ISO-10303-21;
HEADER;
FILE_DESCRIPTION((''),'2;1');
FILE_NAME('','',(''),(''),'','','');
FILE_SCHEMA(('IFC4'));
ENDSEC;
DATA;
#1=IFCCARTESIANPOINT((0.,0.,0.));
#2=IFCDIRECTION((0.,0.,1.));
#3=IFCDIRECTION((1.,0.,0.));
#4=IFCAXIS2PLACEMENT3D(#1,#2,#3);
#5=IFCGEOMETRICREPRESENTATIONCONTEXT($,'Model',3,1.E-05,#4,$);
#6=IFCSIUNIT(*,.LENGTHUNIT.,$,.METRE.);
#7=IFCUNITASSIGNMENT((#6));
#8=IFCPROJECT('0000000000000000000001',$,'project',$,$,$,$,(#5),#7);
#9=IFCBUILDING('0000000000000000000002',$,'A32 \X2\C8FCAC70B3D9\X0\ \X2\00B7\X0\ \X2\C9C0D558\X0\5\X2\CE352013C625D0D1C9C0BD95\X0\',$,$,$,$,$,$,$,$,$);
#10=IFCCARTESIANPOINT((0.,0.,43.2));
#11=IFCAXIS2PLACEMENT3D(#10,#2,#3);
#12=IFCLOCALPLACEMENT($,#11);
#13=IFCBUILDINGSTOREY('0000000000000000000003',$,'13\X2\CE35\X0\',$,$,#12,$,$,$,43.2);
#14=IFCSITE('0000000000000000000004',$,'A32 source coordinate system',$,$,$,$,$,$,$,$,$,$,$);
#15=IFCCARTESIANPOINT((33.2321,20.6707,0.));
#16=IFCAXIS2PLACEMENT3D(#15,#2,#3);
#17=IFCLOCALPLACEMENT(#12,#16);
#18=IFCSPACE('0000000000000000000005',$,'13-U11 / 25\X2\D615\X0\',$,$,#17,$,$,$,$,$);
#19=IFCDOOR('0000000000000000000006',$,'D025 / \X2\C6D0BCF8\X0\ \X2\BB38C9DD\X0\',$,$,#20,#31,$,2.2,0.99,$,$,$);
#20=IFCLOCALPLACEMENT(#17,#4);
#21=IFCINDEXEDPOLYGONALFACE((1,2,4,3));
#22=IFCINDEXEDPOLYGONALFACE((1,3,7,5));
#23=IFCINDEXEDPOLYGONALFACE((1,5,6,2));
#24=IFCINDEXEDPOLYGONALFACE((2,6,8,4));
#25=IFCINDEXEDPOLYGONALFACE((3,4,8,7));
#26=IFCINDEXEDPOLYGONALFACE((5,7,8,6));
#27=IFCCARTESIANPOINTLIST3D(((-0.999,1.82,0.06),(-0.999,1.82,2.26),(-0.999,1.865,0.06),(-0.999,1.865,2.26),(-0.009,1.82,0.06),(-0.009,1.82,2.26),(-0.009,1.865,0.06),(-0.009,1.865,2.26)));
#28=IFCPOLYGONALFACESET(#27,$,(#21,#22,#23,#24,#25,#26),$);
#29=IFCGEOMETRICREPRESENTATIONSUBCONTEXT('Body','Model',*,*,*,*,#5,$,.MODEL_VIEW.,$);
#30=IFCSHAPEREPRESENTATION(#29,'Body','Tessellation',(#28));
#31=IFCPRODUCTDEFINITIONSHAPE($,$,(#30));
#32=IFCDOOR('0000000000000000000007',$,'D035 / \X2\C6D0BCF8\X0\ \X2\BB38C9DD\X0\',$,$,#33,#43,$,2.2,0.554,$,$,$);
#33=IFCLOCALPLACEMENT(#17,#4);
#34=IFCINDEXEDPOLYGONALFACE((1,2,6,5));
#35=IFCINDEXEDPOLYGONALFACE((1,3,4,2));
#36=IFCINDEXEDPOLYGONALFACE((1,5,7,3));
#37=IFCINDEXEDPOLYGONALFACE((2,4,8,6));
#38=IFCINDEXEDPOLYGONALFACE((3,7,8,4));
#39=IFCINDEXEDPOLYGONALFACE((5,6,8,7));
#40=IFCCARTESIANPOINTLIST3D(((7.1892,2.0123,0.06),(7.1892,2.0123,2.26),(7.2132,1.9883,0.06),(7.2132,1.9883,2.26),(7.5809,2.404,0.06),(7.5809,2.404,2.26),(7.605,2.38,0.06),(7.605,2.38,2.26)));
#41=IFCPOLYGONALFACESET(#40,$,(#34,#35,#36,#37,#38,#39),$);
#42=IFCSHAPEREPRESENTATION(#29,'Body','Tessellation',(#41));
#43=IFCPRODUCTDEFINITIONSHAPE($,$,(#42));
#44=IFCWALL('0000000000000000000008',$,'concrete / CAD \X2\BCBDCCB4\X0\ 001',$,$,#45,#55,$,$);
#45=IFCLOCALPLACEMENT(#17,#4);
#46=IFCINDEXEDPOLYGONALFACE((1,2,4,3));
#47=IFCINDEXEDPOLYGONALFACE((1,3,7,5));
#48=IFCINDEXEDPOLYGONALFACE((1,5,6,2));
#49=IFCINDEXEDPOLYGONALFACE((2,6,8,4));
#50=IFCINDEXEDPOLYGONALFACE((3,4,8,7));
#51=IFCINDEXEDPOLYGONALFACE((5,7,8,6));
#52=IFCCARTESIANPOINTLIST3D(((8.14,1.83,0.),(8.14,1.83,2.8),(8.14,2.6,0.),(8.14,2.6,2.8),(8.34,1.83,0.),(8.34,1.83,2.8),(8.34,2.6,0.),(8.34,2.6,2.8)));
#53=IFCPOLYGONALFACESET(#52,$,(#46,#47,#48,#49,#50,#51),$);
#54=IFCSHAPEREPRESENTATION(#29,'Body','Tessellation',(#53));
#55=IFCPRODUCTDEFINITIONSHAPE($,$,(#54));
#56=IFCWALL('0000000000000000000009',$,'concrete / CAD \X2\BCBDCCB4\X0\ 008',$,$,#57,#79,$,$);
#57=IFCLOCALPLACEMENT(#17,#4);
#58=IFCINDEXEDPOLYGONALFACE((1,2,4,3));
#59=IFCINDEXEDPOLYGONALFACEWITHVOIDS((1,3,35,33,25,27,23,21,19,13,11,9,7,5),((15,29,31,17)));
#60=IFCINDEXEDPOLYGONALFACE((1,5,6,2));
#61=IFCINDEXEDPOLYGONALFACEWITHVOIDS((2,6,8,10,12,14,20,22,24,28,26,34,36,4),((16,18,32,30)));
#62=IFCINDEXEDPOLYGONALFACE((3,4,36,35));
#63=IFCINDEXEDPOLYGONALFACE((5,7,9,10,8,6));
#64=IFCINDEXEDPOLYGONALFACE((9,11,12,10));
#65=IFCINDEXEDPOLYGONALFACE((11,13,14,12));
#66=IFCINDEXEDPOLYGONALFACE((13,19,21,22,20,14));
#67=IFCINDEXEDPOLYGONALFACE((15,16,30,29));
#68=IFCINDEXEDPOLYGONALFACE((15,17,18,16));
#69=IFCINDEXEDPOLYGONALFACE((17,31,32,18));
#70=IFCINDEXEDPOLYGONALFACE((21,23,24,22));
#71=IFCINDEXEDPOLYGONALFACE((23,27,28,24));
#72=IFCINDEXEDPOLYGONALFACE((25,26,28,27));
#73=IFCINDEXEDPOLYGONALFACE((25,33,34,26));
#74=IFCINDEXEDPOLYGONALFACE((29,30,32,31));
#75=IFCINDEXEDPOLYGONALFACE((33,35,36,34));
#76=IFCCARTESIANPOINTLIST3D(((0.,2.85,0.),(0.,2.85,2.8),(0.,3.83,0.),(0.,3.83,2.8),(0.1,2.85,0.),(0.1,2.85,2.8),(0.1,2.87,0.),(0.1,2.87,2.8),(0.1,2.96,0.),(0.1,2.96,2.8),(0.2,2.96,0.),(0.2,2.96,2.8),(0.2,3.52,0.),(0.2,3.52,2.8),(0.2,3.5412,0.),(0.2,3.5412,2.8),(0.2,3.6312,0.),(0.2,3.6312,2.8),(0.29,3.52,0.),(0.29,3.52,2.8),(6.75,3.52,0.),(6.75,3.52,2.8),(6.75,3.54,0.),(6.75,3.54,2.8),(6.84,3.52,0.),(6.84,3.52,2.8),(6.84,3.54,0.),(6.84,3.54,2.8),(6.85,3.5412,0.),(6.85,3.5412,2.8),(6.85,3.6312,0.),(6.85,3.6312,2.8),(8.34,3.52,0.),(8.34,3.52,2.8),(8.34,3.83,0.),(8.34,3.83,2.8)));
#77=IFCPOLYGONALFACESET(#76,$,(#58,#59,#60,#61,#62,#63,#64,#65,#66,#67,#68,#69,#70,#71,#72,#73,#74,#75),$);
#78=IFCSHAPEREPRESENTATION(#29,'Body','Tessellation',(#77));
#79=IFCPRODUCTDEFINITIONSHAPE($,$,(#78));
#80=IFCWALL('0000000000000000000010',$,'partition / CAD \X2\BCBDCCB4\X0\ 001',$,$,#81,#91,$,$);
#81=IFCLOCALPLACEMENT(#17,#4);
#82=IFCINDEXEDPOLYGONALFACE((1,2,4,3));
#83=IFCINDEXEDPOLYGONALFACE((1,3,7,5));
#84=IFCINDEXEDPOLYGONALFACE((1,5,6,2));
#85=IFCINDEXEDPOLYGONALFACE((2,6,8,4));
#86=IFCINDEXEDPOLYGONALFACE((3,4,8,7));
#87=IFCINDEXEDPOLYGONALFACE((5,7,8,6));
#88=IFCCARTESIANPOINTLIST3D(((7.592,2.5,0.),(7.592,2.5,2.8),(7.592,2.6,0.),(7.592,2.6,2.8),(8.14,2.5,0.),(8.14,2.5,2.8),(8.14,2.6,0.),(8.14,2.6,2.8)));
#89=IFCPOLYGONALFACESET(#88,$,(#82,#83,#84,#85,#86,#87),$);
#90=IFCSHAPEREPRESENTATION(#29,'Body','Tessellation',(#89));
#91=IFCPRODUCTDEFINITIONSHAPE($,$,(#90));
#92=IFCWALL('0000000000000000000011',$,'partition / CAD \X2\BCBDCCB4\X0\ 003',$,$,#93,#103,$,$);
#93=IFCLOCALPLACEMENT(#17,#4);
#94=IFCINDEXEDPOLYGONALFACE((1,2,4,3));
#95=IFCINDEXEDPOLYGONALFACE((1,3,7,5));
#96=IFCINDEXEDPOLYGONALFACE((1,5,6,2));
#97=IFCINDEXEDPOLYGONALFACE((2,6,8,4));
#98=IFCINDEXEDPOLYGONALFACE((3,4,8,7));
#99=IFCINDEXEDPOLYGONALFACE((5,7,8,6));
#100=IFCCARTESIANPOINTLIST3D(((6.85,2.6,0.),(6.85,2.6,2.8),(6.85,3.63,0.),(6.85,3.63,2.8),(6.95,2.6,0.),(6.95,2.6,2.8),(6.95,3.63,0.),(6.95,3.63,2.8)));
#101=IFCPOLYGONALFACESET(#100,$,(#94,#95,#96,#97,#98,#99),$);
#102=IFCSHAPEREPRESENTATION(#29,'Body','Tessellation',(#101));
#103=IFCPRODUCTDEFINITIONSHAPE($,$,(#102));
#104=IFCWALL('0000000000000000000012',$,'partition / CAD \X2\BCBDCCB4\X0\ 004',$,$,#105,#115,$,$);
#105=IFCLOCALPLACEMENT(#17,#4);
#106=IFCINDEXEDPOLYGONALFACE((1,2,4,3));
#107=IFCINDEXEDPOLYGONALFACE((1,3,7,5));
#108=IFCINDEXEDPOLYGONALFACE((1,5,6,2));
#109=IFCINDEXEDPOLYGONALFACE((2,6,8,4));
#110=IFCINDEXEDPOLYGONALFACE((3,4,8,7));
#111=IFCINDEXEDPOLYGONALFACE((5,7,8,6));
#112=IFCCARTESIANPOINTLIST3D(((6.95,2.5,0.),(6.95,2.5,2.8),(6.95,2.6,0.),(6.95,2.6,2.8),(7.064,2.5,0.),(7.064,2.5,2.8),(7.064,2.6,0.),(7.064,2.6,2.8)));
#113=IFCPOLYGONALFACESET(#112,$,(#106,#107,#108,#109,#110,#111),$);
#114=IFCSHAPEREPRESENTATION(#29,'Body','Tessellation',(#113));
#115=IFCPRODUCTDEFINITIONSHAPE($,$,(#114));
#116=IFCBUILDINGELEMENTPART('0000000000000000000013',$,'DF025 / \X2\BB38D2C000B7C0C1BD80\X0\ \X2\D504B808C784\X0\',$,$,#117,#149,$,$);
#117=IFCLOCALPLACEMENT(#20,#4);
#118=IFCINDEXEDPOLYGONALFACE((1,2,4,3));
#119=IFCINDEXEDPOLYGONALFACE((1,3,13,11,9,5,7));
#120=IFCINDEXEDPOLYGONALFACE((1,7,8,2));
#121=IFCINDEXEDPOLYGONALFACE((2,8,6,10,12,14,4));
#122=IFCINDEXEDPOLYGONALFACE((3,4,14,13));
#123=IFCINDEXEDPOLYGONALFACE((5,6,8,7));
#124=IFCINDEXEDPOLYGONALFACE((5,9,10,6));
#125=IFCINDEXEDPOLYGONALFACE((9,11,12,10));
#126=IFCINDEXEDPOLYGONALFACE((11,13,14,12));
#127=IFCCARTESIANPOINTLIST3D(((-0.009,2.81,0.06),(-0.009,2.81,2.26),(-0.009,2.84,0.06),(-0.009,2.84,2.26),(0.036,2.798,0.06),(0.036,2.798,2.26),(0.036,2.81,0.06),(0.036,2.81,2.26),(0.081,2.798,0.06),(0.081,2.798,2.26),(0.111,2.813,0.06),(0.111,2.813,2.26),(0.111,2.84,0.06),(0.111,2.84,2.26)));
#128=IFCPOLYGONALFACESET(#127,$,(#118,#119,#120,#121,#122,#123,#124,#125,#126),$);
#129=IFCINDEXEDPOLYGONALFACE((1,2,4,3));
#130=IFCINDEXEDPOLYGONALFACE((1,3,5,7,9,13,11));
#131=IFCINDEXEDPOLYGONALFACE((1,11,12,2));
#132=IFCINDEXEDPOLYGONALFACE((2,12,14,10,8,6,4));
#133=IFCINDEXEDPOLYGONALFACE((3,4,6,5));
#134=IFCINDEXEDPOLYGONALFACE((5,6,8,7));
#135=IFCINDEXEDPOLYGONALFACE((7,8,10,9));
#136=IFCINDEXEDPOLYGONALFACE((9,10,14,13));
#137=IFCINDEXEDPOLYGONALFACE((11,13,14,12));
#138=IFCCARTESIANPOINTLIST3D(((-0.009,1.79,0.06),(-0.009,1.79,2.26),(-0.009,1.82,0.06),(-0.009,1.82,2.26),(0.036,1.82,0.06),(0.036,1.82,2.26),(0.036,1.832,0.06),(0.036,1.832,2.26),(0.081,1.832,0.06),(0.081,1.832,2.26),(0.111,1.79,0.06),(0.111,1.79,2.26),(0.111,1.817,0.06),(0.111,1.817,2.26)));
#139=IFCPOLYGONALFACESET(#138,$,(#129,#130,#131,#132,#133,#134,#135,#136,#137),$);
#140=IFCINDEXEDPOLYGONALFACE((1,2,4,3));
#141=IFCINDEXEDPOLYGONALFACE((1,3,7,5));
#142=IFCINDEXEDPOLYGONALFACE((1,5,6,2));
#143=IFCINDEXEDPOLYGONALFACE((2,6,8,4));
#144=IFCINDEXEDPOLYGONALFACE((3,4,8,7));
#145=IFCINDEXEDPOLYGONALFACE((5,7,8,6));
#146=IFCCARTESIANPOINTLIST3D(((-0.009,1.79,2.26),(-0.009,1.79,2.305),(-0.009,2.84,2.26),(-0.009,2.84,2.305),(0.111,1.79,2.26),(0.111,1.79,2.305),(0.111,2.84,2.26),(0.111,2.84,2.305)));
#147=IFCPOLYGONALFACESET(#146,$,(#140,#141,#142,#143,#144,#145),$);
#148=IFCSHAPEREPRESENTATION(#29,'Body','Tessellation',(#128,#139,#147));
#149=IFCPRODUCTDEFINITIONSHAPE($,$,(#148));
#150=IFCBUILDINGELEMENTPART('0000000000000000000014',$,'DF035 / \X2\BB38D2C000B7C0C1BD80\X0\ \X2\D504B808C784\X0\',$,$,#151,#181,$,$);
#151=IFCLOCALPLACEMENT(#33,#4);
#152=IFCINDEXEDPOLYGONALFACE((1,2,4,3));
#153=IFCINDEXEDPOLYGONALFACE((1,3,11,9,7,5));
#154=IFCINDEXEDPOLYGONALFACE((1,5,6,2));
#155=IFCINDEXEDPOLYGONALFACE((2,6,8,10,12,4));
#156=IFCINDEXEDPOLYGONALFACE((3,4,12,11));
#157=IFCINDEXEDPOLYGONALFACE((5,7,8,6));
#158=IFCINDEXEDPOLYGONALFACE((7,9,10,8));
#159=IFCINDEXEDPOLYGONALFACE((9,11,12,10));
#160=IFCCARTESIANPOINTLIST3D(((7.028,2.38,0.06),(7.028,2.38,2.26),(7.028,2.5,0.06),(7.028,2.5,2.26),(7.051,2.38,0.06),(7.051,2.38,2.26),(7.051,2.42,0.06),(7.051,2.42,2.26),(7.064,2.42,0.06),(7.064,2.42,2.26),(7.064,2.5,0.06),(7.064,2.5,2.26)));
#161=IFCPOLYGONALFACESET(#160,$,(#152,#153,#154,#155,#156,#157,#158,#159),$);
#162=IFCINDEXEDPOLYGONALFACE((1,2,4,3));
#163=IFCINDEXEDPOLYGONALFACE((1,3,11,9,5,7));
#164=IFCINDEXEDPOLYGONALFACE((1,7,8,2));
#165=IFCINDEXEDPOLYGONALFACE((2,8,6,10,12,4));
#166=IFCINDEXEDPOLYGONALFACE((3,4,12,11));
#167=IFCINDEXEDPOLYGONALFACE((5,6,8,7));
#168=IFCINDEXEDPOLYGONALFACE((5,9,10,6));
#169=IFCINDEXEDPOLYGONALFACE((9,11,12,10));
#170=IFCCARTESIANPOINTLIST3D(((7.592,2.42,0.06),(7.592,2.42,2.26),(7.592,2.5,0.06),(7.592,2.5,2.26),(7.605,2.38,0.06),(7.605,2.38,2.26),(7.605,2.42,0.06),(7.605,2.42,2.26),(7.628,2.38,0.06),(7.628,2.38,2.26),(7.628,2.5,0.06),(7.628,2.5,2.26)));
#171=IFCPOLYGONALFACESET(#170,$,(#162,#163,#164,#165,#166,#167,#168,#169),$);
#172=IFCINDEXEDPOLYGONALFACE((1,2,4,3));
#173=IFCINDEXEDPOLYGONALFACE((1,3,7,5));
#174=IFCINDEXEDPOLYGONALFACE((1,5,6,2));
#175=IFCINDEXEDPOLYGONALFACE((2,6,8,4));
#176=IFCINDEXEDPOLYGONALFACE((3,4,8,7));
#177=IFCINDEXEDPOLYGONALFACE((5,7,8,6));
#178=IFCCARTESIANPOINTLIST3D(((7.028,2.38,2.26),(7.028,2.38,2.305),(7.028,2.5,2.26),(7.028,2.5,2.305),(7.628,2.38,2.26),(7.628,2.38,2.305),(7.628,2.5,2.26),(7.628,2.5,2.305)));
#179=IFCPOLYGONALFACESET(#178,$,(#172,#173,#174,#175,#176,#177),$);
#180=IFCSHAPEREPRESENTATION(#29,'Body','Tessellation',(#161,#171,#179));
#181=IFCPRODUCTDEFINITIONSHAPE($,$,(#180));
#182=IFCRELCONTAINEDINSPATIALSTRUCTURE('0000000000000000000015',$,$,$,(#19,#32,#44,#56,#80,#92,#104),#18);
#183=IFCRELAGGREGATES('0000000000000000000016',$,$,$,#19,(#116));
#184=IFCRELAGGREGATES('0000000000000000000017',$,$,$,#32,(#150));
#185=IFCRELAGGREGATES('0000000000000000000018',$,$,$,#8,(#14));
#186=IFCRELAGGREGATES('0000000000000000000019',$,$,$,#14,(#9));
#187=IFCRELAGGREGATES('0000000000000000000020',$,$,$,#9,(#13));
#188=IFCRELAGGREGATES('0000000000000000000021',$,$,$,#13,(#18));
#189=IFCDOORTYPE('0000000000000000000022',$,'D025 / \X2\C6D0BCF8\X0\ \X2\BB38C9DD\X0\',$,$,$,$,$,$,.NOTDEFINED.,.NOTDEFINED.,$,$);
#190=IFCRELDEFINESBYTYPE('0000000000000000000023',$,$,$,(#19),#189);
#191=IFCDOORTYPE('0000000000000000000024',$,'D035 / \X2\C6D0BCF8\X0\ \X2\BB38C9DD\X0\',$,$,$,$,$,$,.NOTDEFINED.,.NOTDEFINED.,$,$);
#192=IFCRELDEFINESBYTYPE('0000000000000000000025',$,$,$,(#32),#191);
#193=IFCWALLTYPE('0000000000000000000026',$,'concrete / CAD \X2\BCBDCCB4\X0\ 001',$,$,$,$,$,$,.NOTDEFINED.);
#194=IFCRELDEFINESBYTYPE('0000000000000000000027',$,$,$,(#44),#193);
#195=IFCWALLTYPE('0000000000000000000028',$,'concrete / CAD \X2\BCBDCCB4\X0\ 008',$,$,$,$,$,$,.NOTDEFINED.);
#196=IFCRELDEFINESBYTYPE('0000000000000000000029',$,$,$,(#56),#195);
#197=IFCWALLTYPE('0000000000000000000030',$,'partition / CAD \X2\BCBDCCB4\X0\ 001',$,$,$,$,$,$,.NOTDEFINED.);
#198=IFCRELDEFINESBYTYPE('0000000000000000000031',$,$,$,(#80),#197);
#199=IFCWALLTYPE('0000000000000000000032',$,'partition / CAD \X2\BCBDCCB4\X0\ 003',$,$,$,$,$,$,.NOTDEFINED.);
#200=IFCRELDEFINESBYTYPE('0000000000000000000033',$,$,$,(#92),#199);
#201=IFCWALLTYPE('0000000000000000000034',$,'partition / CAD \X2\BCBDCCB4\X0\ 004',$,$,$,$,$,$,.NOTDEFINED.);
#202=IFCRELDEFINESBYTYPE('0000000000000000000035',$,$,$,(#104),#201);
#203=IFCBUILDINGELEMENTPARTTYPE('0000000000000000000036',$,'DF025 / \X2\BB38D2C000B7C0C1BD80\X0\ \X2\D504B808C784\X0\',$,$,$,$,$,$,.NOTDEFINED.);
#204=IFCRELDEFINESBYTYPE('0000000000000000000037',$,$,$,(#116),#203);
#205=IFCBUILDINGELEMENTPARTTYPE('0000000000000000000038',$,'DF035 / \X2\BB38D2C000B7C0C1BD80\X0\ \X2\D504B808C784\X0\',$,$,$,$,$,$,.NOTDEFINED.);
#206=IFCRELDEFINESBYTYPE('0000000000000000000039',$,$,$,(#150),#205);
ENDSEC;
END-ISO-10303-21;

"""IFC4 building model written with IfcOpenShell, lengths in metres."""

from ifc_helpers import new_model, si_unit, frame, origin, origin_with_axes, place, context, subcontext, project, spatial, polyline, outline, extrude, source, transform, mapped, type_object, type_shapes, element, aggregate, save


model = new_model("IFC4")

# Units and contexts
model_context = context("Model", 3, precision=1e-05, world=origin_with_axes())
body_context = subcontext(model_context, "Body", "Model", "MODEL_VIEW")
ifc_project = project(units=[si_unit("LENGTHUNIT", "METRE")], contexts=[model_context])

# Site, building, storey, space
storey_placement = place(None, frame((0.0, 0.0, 43.2), z_axis=(0.0, 0.0, 1.0), x_axis=(1.0, 0.0, 0.0)))
space_placement = place(storey_placement, frame((33.2321, 20.6707, 0.0), z_axis=(0.0, 0.0, 1.0), x_axis=(1.0, 0.0, 0.0)))
site = spatial("IfcSite", under=ifc_project, Name="A32 source coordinate system")
building = spatial("IfcBuilding", under=site, Name="A32 주거동 · 지하5층–옥탑지붕")
storey = spatial("IfcBuildingStorey", under=building, at=storey_placement, Name="13층", Elevation=43.2)
space = spatial("IfcSpace", under=storey, at=space_placement, Name="13-U11 / 25형")

# Doors
door_type_1 = type_object("IfcDoorType", Name="D025 / 원본 문짝", OperationType="NOTDEFINED", PredefinedType="NOTDEFINED")
shared_shape_1 = source(origin(), body_context, "Body", "SweptSolid", [
    extrude(outline(polyline([(-0.009, 1.82), (-0.999, 1.82), (-0.999, 1.865), (-0.009, 1.865), (-0.009, 1.82)])), frame((0.0, 0.0, 0.06)), (0.0, 0.0, 1.0), 2.2),
])
type_shapes(door_type_1, [shared_shape_1])
door_1_placement = place(space_placement, origin_with_axes())
door_1 = element("IfcDoor", 1, at=door_1_placement, inside=space, type_object=door_type_1, Name="D025 / 원본 문짝", OverallHeight=2.2, OverallWidth=0.99, context=body_context, shape_type="MappedRepresentation", body=[
    mapped(shared_shape_1, transform((0.0, 0.0, 0.0), scale=1.0)),
])
door_type_2 = type_object("IfcDoorType", Name="D035 / 원본 문짝", OperationType="NOTDEFINED", PredefinedType="NOTDEFINED")
shared_shape_2 = source(origin(), body_context, "Body", "SweptSolid", [
    extrude(outline(polyline([(7.605, 2.38), (7.2132, 1.9883), (7.1892, 2.0123), (7.5809, 2.404), (7.605, 2.38)])), frame((0.0, 0.0, 0.06)), (0.0, 0.0, 1.0), 2.2),
])
type_shapes(door_type_2, [shared_shape_2])
door_2_placement = place(space_placement, origin_with_axes())
door_2 = element("IfcDoor", 2, at=door_2_placement, inside=space, type_object=door_type_2, Name="D035 / 원본 문짝", OverallHeight=2.2, OverallWidth=0.554, context=body_context, shape_type="MappedRepresentation", body=[
    mapped(shared_shape_2, transform((0.0, 0.0, 0.0), scale=1.0)),
])

# Walls
wall_type_1 = type_object("IfcWallType", Name="concrete / CAD 벽체 001", PredefinedType="NOTDEFINED")
shared_shape_3 = source(origin(), body_context, "Body", "SweptSolid", [
    extrude(outline(polyline([(8.34, 1.83), (8.14, 1.83), (8.14, 2.6), (8.34, 2.6), (8.34, 1.83)])), origin(), (0.0, 0.0, 1.0), 2.8),
])
type_shapes(wall_type_1, [shared_shape_3])
wall_1_placement = place(space_placement, origin_with_axes())
element("IfcWall", 3, at=wall_1_placement, inside=space, type_object=wall_type_1, Name="concrete / CAD 벽체 001", context=body_context, shape_type="MappedRepresentation", body=[
    mapped(shared_shape_3, transform((0.0, 0.0, 0.0), scale=1.0)),
])
wall_type_2 = type_object("IfcWallType", Name="concrete / CAD 벽체 008", PredefinedType="NOTDEFINED")
shared_shape_4 = source(origin(), body_context, "Body", "SweptSolid", [
    extrude(outline(polyline([(0.0, 3.83), (8.34, 3.83), (8.34, 3.52), (6.84, 3.52), (6.84, 3.54), (6.75, 3.54), (6.75, 3.52), (0.29, 3.52), (0.2, 3.52), (0.2, 2.96), (0.1, 2.96), (0.1, 2.87), (0.1, 2.85), (0.0, 2.85), (0.0, 3.83)]), holes=[polyline([(6.85, 3.5412), (6.85, 3.6312), (0.2, 3.6312), (0.2, 3.5412), (6.85, 3.5412)])]), origin(), (0.0, 0.0, 1.0), 2.8),
])
type_shapes(wall_type_2, [shared_shape_4])
wall_2_placement = place(space_placement, origin_with_axes())
element("IfcWall", 4, at=wall_2_placement, inside=space, type_object=wall_type_2, Name="concrete / CAD 벽체 008", context=body_context, shape_type="MappedRepresentation", body=[
    mapped(shared_shape_4, transform((0.0, 0.0, 0.0), scale=1.0)),
])
wall_type_3 = type_object("IfcWallType", Name="partition / CAD 벽체 001", PredefinedType="NOTDEFINED")
shared_shape_5 = source(origin(), body_context, "Body", "SweptSolid", [
    extrude(outline(polyline([(8.14, 2.6), (8.14, 2.5), (7.592, 2.5), (7.592, 2.6), (8.14, 2.6)])), origin(), (0.0, 0.0, 1.0), 2.8),
])
type_shapes(wall_type_3, [shared_shape_5])
wall_3_placement = place(space_placement, origin_with_axes())
element("IfcWall", 5, at=wall_3_placement, inside=space, type_object=wall_type_3, Name="partition / CAD 벽체 001", context=body_context, shape_type="MappedRepresentation", body=[
    mapped(shared_shape_5, transform((0.0, 0.0, 0.0), scale=1.0)),
])
wall_type_4 = type_object("IfcWallType", Name="partition / CAD 벽체 003", PredefinedType="NOTDEFINED")
shared_shape_6 = source(origin(), body_context, "Body", "SweptSolid", [
    extrude(outline(polyline([(6.85, 2.6), (6.85, 3.63), (6.95, 3.63), (6.95, 2.6), (6.85, 2.6)])), origin(), (0.0, 0.0, 1.0), 2.8),
])
type_shapes(wall_type_4, [shared_shape_6])
wall_4_placement = place(space_placement, origin_with_axes())
element("IfcWall", 6, at=wall_4_placement, inside=space, type_object=wall_type_4, Name="partition / CAD 벽체 003", context=body_context, shape_type="MappedRepresentation", body=[
    mapped(shared_shape_6, transform((0.0, 0.0, 0.0), scale=1.0)),
])
wall_type_5 = type_object("IfcWallType", Name="partition / CAD 벽체 004", PredefinedType="NOTDEFINED")
shared_shape_7 = source(origin(), body_context, "Body", "SweptSolid", [
    extrude(outline(polyline([(6.95, 2.5), (6.95, 2.6), (7.064, 2.6), (7.064, 2.5), (6.95, 2.5)])), origin(), (0.0, 0.0, 1.0), 2.8),
])
type_shapes(wall_type_5, [shared_shape_7])
wall_5_placement = place(space_placement, origin_with_axes())
element("IfcWall", 7, at=wall_5_placement, inside=space, type_object=wall_type_5, Name="partition / CAD 벽체 004", context=body_context, shape_type="MappedRepresentation", body=[
    mapped(shared_shape_7, transform((0.0, 0.0, 0.0), scale=1.0)),
])

# Building element parts
building_element_part_type_1 = type_object("IfcBuildingElementPartType", Name="DF025 / 문틀·상부 프레임", PredefinedType="NOTDEFINED")
shared_shape_8 = source(origin(), body_context, "Body", "SweptSolid", [
    extrude(outline(polyline([(0.111, 2.84), (0.111, 2.813), (0.081, 2.798), (0.036, 2.798), (0.036, 2.81), (-0.009, 2.81), (-0.009, 2.84), (0.111, 2.84)])), frame((0.0, 0.0, 0.06)), (0.0, 0.0, 1.0), 2.2),
    extrude(outline(polyline([(-0.009, 1.82), (0.036, 1.82), (0.036, 1.832), (0.081, 1.832), (0.111, 1.817), (0.111, 1.79), (-0.009, 1.79), (-0.009, 1.82)])), frame((0.0, 0.0, 0.06)), (0.0, 0.0, 1.0), 2.2),
    extrude(outline(polyline([(-0.009, 1.79), (-0.009, 2.84), (0.111, 2.84), (0.111, 1.79), (-0.009, 1.79)])), frame((0.0, 0.0, 2.26)), (0.0, 0.0, 1.0), 0.045),
])
type_shapes(building_element_part_type_1, [shared_shape_8])
building_element_part_1_placement = place(door_1_placement, origin_with_axes())
building_element_part_1 = element("IfcBuildingElementPart", 8, at=building_element_part_1_placement, type_object=building_element_part_type_1, Name="DF025 / 문틀·상부 프레임", context=body_context, shape_type="MappedRepresentation", body=[
    mapped(shared_shape_8, transform((0.0, 0.0, 0.0), scale=1.0)),
])
aggregate(door_1, [building_element_part_1])
building_element_part_type_2 = type_object("IfcBuildingElementPartType", Name="DF035 / 문틀·상부 프레임", PredefinedType="NOTDEFINED")
shared_shape_9 = source(origin(), body_context, "Body", "SweptSolid", [
    extrude(outline(polyline([(7.064, 2.5), (7.064, 2.42), (7.051, 2.42), (7.051, 2.38), (7.028, 2.38), (7.028, 2.5), (7.064, 2.5)])), frame((0.0, 0.0, 0.06)), (0.0, 0.0, 1.0), 2.2),
    extrude(outline(polyline([(7.628, 2.38), (7.605, 2.38), (7.605, 2.42), (7.592, 2.42), (7.592, 2.5), (7.628, 2.5), (7.628, 2.38)])), frame((0.0, 0.0, 0.06)), (0.0, 0.0, 1.0), 2.2),
    extrude(outline(polyline([(7.028, 2.38), (7.028, 2.5), (7.628, 2.5), (7.628, 2.38), (7.028, 2.38)])), frame((0.0, 0.0, 2.26)), (0.0, 0.0, 1.0), 0.045),
])
type_shapes(building_element_part_type_2, [shared_shape_9])
building_element_part_2_placement = place(door_2_placement, origin_with_axes())
building_element_part_2 = element("IfcBuildingElementPart", 9, at=building_element_part_2_placement, type_object=building_element_part_type_2, Name="DF035 / 문틀·상부 프레임", context=body_context, shape_type="MappedRepresentation", body=[
    mapped(shared_shape_9, transform((0.0, 0.0, 0.0), scale=1.0)),
])
aggregate(door_2, [building_element_part_2])

save(model, "model.ifc")
